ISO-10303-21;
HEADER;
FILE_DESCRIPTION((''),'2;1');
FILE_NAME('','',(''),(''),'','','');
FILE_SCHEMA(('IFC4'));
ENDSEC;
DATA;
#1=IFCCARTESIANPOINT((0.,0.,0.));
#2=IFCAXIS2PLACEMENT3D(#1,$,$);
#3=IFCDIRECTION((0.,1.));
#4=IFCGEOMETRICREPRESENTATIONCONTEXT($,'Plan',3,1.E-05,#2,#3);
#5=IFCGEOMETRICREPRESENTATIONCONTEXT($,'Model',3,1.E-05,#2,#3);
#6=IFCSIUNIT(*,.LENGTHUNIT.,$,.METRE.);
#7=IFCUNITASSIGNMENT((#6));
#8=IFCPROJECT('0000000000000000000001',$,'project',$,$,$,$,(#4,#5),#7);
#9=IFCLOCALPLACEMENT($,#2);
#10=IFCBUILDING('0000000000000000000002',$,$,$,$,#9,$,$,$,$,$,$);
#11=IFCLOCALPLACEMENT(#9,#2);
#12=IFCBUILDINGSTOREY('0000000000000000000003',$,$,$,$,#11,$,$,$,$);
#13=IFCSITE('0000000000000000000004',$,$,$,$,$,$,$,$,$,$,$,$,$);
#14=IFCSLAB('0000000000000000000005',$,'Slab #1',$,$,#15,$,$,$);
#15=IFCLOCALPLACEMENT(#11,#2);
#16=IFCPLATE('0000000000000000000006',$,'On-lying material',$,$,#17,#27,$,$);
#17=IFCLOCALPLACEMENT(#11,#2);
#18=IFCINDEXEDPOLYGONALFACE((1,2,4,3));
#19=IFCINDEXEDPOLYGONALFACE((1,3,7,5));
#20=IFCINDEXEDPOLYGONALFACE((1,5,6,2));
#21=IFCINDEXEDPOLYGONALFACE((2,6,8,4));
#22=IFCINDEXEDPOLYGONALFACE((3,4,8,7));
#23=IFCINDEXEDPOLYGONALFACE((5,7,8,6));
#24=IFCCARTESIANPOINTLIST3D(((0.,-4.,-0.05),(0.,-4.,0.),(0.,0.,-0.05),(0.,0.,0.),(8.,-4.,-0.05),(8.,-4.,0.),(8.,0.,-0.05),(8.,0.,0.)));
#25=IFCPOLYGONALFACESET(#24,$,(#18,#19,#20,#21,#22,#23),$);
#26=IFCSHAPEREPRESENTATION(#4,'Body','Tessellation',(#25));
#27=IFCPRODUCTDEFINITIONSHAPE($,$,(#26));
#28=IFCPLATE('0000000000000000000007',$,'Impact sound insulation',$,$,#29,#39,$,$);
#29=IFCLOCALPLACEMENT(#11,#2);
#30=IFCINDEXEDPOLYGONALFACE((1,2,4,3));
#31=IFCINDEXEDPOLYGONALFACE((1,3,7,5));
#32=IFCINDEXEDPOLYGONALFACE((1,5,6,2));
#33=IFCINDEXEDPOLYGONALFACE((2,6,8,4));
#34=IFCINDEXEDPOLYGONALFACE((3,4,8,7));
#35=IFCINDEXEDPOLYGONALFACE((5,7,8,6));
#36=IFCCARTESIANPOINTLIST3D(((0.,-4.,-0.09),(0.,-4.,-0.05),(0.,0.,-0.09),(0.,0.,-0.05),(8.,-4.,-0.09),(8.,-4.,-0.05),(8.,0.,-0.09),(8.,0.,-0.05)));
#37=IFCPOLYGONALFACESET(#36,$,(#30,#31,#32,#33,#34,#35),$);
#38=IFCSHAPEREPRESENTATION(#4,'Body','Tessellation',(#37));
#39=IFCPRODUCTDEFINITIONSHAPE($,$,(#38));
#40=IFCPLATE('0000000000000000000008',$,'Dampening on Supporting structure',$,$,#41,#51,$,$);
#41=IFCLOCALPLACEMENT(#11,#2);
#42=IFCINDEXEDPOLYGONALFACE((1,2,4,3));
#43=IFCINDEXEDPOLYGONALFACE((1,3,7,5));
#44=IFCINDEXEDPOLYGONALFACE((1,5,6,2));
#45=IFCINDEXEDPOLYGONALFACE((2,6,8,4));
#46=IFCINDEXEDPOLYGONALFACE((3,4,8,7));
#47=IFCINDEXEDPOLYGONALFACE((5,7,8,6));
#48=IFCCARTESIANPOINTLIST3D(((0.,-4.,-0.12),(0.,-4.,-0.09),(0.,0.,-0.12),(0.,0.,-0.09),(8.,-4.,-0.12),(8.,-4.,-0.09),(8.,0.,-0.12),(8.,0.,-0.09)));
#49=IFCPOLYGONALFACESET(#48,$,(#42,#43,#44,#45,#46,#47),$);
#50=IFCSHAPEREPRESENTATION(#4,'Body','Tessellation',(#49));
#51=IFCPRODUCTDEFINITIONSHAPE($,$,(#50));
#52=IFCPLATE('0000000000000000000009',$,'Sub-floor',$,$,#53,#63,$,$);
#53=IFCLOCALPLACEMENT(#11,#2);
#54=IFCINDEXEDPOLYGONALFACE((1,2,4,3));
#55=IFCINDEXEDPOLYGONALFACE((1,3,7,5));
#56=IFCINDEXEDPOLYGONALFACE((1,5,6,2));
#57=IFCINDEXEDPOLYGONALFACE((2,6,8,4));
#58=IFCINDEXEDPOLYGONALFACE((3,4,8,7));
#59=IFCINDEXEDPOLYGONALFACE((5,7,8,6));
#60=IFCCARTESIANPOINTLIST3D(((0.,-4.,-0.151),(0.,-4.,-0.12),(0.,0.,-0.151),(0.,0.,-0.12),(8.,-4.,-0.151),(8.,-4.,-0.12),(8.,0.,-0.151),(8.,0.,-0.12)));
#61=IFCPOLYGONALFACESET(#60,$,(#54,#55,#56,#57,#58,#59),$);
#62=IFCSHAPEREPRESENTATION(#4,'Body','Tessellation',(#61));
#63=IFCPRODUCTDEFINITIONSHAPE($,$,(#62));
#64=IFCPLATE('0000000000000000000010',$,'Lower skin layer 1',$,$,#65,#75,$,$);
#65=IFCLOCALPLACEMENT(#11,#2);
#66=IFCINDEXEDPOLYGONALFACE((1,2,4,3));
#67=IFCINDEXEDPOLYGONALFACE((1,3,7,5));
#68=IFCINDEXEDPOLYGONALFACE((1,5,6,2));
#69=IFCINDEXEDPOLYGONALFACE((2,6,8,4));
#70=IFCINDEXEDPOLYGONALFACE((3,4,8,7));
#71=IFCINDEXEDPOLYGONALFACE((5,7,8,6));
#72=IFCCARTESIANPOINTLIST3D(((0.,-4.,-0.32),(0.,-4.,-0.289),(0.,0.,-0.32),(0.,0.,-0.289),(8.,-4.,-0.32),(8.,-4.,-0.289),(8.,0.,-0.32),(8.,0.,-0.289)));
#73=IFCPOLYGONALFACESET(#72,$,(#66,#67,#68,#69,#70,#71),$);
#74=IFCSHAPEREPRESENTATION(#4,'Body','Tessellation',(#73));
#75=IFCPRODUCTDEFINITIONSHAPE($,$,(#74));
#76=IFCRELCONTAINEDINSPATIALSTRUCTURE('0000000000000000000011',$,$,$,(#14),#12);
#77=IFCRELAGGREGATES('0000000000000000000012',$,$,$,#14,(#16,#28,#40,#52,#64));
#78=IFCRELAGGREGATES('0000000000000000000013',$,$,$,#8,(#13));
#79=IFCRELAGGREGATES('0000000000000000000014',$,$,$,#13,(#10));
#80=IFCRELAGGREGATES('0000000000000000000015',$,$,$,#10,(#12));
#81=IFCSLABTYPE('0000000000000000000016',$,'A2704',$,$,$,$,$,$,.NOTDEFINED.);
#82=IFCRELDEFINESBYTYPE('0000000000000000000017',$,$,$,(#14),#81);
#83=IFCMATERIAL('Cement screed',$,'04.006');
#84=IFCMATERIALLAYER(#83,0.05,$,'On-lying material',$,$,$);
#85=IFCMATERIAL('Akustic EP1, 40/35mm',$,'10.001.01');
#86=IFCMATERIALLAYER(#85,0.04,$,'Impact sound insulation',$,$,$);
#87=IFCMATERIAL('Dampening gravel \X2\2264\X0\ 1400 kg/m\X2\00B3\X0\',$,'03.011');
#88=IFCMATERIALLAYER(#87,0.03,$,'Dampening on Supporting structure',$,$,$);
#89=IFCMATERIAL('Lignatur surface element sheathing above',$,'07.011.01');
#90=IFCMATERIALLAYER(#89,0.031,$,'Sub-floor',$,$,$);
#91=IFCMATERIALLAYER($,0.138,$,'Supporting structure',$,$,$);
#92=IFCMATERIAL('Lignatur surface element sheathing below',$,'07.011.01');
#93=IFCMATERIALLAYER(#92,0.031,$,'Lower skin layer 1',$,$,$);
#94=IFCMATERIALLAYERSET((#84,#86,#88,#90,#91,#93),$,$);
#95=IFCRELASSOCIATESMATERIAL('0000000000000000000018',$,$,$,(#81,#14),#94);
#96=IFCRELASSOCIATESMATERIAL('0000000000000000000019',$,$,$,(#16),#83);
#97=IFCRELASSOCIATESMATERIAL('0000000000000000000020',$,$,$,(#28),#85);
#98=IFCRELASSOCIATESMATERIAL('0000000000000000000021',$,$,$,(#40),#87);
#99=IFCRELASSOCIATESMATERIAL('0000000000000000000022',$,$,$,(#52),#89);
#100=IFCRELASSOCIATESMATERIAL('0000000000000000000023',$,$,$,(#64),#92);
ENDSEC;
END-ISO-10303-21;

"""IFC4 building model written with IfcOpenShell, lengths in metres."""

from ifc_helpers import new_model, si_unit, direction, frame, frame_2d, origin, origin_with_axes, place, context, project, spatial, rectangle, extrude, material, layer, layer_set, type_object, element, aggregate, save


model = new_model("IFC4")

# Units and contexts
plan_context = context("Plan", 3, precision=1e-05, world=origin(), true_north=direction((0.0, 1.0)))
model_context = context("Model", 3, precision=1e-05, world=origin(), true_north=direction((0.0, 1.0)))
ifc_project = project(units=[si_unit("LENGTHUNIT", "METRE")], contexts=[plan_context, model_context])

# Site, building, storey
site = spatial("IfcSite", under=ifc_project)
building_placement = place(None, origin())
building = spatial("IfcBuilding", under=site, at=building_placement)
storey_placement = place(building_placement, origin())
storey = spatial("IfcBuildingStorey", under=building, at=storey_placement)

# Slab, plates
ifc_material_1 = material(Name="Cement screed", Category="04.006")
ifc_layer_1 = layer(ifc_material_1, 0.05, Name="On-lying material")
ifc_material_2 = material(Name="Akustic EP1, 40/35mm", Category="10.001.01")
ifc_layer_2 = layer(ifc_material_2, 0.04, Name="Impact sound insulation")
ifc_material_3 = material(Name="Dampening gravel ≤ 1400 kg/m³", Category="03.011")
ifc_layer_3 = layer(ifc_material_3, 0.03, Name="Dampening on Supporting structure")
ifc_material_4 = material(Name="Lignatur surface element sheathing above", Category="07.011.01")
ifc_layer_4 = layer(ifc_material_4, 0.031, Name="Sub-floor")
ifc_layer_5 = layer(None, 0.138, Name="Supporting structure")
ifc_material_5 = material(Name="Lignatur surface element sheathing below", Category="07.011.01")
ifc_layer_6 = layer(ifc_material_5, 0.031, Name="Lower skin layer 1")
ifc_layer_set = layer_set([ifc_layer_1, ifc_layer_2, ifc_layer_3, ifc_layer_4, ifc_layer_5, ifc_layer_6])
slab_type = type_object("IfcSlabType", Name="A2704", PredefinedType="NOTDEFINED", material=ifc_layer_set)
slab_placement = place(None, frame((0.0, 0.0, 0.0), z_axis=(0.0, 0.0, -1.0), x_axis=(1.0, 0.0, 0.0)))
slab = element("IfcSlab", 1, at=slab_placement, inside=storey, type_object=slab_type, material=ifc_layer_set, Name="Slab #1")
plate_1_placement = place(slab_placement, origin())
plate_1 = element("IfcPlate", 2, at=plate_1_placement, material=ifc_material_1, Name="On-lying material", context=plan_context, shape_type="SweptSolid", body=[
    extrude(rectangle(XDim=8.0, YDim=4.0, at=frame_2d((4.0, 2.0), x_axis=(1.0, 0.0))), origin_with_axes(), (0.0, 0.0, 1.0), 0.05),
])
plate_2_placement = place(slab_placement, origin())
plate_2 = element("IfcPlate", 3, at=plate_2_placement, material=ifc_material_2, Name="Impact sound insulation", context=plan_context, shape_type="SweptSolid", body=[
    extrude(rectangle(XDim=8.0, YDim=4.0, at=frame_2d((4.0, 2.0), x_axis=(1.0, 0.0))), frame((0.0, 0.0, 0.05), z_axis=(0.0, 0.0, 1.0), x_axis=(1.0, 0.0, 0.0)), (0.0, 0.0, 1.0), 0.04),
])
plate_3_placement = place(slab_placement, origin())
plate_3 = element("IfcPlate", 4, at=plate_3_placement, material=ifc_material_3, Name="Dampening on Supporting structure", context=plan_context, shape_type="SweptSolid", body=[
    extrude(rectangle(XDim=8.0, YDim=4.0, at=frame_2d((4.0, 2.0), x_axis=(1.0, 0.0))), frame((0.0, 0.0, 0.09), z_axis=(0.0, 0.0, 1.0), x_axis=(1.0, 0.0, 0.0)), (0.0, 0.0, 1.0), 0.03),
])
plate_4_placement = place(slab_placement, origin())
plate_4 = element("IfcPlate", 5, at=plate_4_placement, material=ifc_material_4, Name="Sub-floor", context=plan_context, shape_type="SweptSolid", body=[
    extrude(rectangle(XDim=8.0, YDim=4.0, at=frame_2d((4.0, 2.0), x_axis=(1.0, 0.0))), frame((0.0, 0.0, 0.12), z_axis=(0.0, 0.0, 1.0), x_axis=(1.0, 0.0, 0.0)), (0.0, 0.0, 1.0), 0.031),
])
plate_5_placement = place(slab_placement, origin())
plate_5 = element("IfcPlate", 6, at=plate_5_placement, material=ifc_material_5, Name="Lower skin layer 1", context=plan_context, shape_type="SweptSolid", body=[
    extrude(rectangle(XDim=8.0, YDim=4.0, at=frame_2d((4.0, 2.0), x_axis=(1.0, 0.0))), frame((0.0, 0.0, 0.289), z_axis=(0.0, 0.0, 1.0), x_axis=(1.0, 0.0, 0.0)), (0.0, 0.0, 1.0), 0.031),
])
aggregate(slab, [plate_1, plate_2, plate_3, plate_4, plate_5])

save(model, "model.ifc")
